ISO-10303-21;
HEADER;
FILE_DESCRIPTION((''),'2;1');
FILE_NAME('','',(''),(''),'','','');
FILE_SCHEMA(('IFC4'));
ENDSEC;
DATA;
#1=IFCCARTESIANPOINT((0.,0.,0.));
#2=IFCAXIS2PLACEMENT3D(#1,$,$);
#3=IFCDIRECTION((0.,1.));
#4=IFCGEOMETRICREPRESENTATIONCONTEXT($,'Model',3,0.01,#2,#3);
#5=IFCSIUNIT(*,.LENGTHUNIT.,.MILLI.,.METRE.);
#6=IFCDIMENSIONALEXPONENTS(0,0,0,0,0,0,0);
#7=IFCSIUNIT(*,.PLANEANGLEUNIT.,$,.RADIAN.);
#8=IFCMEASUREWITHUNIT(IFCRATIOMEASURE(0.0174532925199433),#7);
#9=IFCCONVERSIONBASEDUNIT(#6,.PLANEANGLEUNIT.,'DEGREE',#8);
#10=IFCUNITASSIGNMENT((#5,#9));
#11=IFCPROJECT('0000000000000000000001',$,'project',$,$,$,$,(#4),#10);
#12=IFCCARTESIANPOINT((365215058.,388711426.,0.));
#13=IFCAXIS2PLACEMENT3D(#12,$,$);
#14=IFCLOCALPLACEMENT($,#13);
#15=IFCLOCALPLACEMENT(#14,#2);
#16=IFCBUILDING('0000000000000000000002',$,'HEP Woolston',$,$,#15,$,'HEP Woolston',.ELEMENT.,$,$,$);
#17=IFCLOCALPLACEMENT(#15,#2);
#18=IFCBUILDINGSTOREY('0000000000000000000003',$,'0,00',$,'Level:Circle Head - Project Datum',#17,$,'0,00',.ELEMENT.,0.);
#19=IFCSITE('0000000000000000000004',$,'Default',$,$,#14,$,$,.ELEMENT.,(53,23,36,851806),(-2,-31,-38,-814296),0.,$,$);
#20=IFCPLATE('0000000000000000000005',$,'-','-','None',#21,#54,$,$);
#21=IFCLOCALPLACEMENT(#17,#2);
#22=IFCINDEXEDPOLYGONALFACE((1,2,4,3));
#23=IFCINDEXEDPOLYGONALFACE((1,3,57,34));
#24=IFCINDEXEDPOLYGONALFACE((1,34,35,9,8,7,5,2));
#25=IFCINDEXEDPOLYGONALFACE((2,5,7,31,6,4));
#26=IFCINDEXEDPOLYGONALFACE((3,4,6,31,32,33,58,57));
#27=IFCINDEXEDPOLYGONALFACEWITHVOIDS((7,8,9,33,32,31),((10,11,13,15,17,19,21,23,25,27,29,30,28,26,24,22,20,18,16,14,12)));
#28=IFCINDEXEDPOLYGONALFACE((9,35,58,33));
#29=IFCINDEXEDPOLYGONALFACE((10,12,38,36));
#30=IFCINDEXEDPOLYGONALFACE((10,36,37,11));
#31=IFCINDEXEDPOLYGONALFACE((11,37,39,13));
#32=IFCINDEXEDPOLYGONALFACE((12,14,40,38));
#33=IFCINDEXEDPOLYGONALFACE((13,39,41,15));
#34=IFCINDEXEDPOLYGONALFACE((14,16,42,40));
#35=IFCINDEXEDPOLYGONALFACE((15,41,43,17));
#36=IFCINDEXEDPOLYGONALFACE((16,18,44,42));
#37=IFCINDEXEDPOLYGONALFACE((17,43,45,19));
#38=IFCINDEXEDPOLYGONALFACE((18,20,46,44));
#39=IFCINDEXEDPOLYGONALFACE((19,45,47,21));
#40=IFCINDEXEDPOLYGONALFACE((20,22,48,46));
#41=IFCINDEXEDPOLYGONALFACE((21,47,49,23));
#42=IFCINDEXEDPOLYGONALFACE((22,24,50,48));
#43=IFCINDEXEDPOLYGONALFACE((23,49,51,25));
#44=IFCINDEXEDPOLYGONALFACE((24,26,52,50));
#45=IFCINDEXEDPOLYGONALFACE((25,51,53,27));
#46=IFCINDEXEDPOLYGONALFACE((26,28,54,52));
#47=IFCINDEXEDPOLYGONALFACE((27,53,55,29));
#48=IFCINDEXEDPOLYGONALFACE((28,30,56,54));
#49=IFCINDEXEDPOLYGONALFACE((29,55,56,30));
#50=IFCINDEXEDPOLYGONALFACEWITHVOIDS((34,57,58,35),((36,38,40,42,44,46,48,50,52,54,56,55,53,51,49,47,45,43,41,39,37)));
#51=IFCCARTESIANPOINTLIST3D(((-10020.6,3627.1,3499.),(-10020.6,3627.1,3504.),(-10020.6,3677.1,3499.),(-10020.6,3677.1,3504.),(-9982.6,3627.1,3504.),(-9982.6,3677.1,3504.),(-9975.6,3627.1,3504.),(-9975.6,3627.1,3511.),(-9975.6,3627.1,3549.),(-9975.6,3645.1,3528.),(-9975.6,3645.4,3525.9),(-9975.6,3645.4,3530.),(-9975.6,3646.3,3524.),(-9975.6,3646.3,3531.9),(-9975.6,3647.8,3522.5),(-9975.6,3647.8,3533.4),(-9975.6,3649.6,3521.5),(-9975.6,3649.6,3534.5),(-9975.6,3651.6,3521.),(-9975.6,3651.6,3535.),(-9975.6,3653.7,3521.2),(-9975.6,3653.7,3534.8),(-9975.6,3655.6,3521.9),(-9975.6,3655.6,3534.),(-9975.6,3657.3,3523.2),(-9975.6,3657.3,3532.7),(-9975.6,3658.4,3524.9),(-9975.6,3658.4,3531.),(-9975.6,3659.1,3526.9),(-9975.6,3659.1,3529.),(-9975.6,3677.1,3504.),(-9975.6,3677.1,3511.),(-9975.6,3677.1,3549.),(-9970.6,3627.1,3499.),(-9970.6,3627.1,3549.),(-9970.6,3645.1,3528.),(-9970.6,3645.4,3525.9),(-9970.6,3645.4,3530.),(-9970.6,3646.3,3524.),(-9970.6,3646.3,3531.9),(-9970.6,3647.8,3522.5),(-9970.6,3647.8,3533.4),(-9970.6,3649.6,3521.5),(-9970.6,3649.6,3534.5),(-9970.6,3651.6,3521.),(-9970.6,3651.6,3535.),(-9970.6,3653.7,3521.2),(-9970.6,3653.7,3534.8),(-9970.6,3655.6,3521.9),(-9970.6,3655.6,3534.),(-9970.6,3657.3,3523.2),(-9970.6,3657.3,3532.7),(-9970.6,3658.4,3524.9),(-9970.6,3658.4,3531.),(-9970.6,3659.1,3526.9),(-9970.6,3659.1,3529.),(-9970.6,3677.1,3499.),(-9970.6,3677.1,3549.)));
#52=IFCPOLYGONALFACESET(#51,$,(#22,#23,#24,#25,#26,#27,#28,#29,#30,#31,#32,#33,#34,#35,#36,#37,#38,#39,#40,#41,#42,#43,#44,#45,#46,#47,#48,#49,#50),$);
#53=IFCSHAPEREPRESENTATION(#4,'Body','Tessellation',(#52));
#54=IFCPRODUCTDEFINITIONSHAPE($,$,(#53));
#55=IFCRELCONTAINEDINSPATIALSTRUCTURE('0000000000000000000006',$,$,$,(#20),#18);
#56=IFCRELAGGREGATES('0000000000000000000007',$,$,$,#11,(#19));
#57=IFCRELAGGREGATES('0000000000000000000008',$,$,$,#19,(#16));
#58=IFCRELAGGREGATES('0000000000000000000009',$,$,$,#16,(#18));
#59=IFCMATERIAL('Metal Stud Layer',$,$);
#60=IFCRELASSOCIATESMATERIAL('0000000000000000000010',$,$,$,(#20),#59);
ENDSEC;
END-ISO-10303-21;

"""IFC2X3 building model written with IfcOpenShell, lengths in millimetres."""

from ifc_helpers import new_model, entity, si_unit, converted_unit, point, direction, frame, frame_2d, origin, origin_with_axes, origin_2d_with_axis, place, context, project, spatial, polyline, circle_curve, line_curve, trimmed, segment, composite_curve, circle, outline, extrude, material, element, save


model = new_model("IFC2X3")

# Units and contexts
model_context = context("Model", 3, precision=0.01, world=origin(), true_north=direction((0.0, 1.0)))
ifc_project = project(units=[si_unit("LENGTHUNIT", "METRE", prefix="MILLI"), converted_unit("PLANEANGLEUNIT", "DEGREE", entity("IfcRatioMeasure", 0.0174532925199433), si_unit("PLANEANGLEUNIT", "RADIAN"), dimensions=[0, 0, 0, 0, 0, 0, 0])], contexts=[model_context])

# Site, building, storey
site_placement = place(None, frame((365215058.0, 388711426.0, 0.0)))
site = spatial("IfcSite", under=ifc_project, at=site_placement, Name="Default", CompositionType="ELEMENT", RefLatitude=(53, 23, 36, 851806), RefLongitude=(-2, -31, -38, -814296), RefElevation=0.0)
building_placement = place(site_placement, origin())
building = spatial("IfcBuilding", under=site, at=building_placement, Name="HEP Woolston", LongName="HEP Woolston", CompositionType="ELEMENT")
storey_placement = place(building_placement, origin())
storey = spatial("IfcBuildingStorey", under=building, at=storey_placement, Name="0,00", ObjectType="Level:Circle Head - Project Datum", LongName="0,00", CompositionType="ELEMENT", Elevation=0.0)

# Plate, openings
ifc_material = material(Name="Metal Stud Layer")
plate_1_placement = place(storey_placement, frame((-9970.6, 3627.1, 3499.0), z_axis=(0.0, 1.0, 0.0), x_axis=(-1.0, 0.0, 0.0)))
plate_1 = element("IfcPlate", 1, at=plate_1_placement, inside=storey, material=ifc_material, Name="-", Description="-", ObjectType="None", context=model_context, shape_type="SweptSolid", body=[
    extrude(outline(polyline([(0.0, 0.0), (50.0, 0.0), (50.0, 5.0), (5.0, 5.0), (5.0, 50.0), (0.0, 50.0), (0.0, 0.0)])), origin_with_axes(), (0.0, 0.0, 1.0), 50.0),
])
opening_1_placement = place(plate_1_placement, frame((0.0, 0.0, 0.0), z_axis=(0.0, 0.0, 1.0), x_axis=(1.0, 0.0, 0.0)))
element("IfcOpeningElement", 2, at=opening_1_placement, cuts=plate_1, ObjectType="Opening", context=model_context, shape_type="SweptSolid", body=[
    extrude(outline(composite_curve([segment(trimmed(line_curve((50.0, 5.0), (1.0, 0.0), 3.532613), [point((50.0, 5.0))], [point((46.5, 5.0))], True, "CARTESIAN"), True, "CONTINUOUS"), segment(trimmed(circle_curve(frame_2d((46.5, 1.5), x_axis=(-1.0, 0.0)), 3.5), [point((46.5, 5.0))], [point((50.0, 1.5))], False, "CARTESIAN"), True, "CONTINUOUS"), segment(trimmed(line_curve((50.0, 1.5), (0.0, -1.0), 3.532613), [point((50.0, 1.5))], [point((50.0, 5.0))], True, "CARTESIAN"), True, "CONTINUOUS")], self_intersect="UNKNOWN")), origin(), (0.0, 0.0, 1.0), 50.0),
])
opening_2_placement = place(plate_1_placement, origin_with_axes())
element("IfcOpeningElement", 3, at=opening_2_placement, cuts=plate_1, ObjectType="Opening", context=model_context, shape_type="SweptSolid", body=[
    extrude(outline(composite_curve([segment(trimmed(line_curve((5.0, 5.0), (0.0, -1.0), 7.046301), [point((5.0, 5.0))], [point((5.0, 12.0))], False, "CARTESIAN"), True, "CONTINUOUS"), segment(trimmed(circle_curve(frame_2d((12.0, 12.0), x_axis=(1.0, 0.0)), 7.0), [point((5.0, 12.0))], [point((12.0, 5.0))], True, "CARTESIAN"), True, "CONTINUOUS"), segment(trimmed(line_curve((12.0, 5.0), (1.0, 0.0), 7.046301), [point((12.0, 5.0))], [point((5.0, 5.0))], False, "CARTESIAN"), True, "CONTINUOUS")], self_intersect="UNKNOWN")), origin(), (0.0, 0.0, 1.0), 50.0),
])
opening_3_placement = place(plate_1_placement, frame((0.0, 0.0, 0.0), z_axis=(0.0, 0.0, 1.0), x_axis=(1.0, 0.0, 0.0)))
element("IfcOpeningElement", 4, at=opening_3_placement, cuts=plate_1, ObjectType="Opening", context=model_context, shape_type="SweptSolid", body=[
    extrude(outline(composite_curve([segment(trimmed(line_curve((5.0, 50.0), (1.0, 0.0), 3.4874), [point((5.0, 50.0))], [point((1.5, 50.0))], True, "CARTESIAN"), True, "CONTINUOUS"), segment(trimmed(circle_curve(frame_2d((1.5, 46.5), x_axis=(-1.0, 0.0)), 3.5), [point((1.5, 50.0))], [point((5.0, 46.5))], False, "CARTESIAN"), True, "CONTINUOUS"), segment(trimmed(line_curve((5.0, 46.5), (0.0, -1.0), 3.4874), [point((5.0, 46.5))], [point((5.0, 50.0))], True, "CARTESIAN"), True, "CONTINUOUS")], self_intersect="UNKNOWN")), origin(), (0.0, 0.0, 1.0), 50.0),
])
opening_4_placement = place(plate_1_placement, frame((-0.5, 29.0, 25.0), z_axis=(1.0, 0.0, 0.0), x_axis=(0.0, 0.0, -1.0)))
element("IfcOpeningElement", 5, at=opening_4_placement, cuts=plate_1, ObjectType="Opening", context=model_context, shape_type="SweptSolid", body=[
    extrude(circle(Radius=7.0, at=origin_2d_with_axis()), origin(), (0.0, 0.0, 1.0), 6.0),
])

save(model, "model.ifc")
